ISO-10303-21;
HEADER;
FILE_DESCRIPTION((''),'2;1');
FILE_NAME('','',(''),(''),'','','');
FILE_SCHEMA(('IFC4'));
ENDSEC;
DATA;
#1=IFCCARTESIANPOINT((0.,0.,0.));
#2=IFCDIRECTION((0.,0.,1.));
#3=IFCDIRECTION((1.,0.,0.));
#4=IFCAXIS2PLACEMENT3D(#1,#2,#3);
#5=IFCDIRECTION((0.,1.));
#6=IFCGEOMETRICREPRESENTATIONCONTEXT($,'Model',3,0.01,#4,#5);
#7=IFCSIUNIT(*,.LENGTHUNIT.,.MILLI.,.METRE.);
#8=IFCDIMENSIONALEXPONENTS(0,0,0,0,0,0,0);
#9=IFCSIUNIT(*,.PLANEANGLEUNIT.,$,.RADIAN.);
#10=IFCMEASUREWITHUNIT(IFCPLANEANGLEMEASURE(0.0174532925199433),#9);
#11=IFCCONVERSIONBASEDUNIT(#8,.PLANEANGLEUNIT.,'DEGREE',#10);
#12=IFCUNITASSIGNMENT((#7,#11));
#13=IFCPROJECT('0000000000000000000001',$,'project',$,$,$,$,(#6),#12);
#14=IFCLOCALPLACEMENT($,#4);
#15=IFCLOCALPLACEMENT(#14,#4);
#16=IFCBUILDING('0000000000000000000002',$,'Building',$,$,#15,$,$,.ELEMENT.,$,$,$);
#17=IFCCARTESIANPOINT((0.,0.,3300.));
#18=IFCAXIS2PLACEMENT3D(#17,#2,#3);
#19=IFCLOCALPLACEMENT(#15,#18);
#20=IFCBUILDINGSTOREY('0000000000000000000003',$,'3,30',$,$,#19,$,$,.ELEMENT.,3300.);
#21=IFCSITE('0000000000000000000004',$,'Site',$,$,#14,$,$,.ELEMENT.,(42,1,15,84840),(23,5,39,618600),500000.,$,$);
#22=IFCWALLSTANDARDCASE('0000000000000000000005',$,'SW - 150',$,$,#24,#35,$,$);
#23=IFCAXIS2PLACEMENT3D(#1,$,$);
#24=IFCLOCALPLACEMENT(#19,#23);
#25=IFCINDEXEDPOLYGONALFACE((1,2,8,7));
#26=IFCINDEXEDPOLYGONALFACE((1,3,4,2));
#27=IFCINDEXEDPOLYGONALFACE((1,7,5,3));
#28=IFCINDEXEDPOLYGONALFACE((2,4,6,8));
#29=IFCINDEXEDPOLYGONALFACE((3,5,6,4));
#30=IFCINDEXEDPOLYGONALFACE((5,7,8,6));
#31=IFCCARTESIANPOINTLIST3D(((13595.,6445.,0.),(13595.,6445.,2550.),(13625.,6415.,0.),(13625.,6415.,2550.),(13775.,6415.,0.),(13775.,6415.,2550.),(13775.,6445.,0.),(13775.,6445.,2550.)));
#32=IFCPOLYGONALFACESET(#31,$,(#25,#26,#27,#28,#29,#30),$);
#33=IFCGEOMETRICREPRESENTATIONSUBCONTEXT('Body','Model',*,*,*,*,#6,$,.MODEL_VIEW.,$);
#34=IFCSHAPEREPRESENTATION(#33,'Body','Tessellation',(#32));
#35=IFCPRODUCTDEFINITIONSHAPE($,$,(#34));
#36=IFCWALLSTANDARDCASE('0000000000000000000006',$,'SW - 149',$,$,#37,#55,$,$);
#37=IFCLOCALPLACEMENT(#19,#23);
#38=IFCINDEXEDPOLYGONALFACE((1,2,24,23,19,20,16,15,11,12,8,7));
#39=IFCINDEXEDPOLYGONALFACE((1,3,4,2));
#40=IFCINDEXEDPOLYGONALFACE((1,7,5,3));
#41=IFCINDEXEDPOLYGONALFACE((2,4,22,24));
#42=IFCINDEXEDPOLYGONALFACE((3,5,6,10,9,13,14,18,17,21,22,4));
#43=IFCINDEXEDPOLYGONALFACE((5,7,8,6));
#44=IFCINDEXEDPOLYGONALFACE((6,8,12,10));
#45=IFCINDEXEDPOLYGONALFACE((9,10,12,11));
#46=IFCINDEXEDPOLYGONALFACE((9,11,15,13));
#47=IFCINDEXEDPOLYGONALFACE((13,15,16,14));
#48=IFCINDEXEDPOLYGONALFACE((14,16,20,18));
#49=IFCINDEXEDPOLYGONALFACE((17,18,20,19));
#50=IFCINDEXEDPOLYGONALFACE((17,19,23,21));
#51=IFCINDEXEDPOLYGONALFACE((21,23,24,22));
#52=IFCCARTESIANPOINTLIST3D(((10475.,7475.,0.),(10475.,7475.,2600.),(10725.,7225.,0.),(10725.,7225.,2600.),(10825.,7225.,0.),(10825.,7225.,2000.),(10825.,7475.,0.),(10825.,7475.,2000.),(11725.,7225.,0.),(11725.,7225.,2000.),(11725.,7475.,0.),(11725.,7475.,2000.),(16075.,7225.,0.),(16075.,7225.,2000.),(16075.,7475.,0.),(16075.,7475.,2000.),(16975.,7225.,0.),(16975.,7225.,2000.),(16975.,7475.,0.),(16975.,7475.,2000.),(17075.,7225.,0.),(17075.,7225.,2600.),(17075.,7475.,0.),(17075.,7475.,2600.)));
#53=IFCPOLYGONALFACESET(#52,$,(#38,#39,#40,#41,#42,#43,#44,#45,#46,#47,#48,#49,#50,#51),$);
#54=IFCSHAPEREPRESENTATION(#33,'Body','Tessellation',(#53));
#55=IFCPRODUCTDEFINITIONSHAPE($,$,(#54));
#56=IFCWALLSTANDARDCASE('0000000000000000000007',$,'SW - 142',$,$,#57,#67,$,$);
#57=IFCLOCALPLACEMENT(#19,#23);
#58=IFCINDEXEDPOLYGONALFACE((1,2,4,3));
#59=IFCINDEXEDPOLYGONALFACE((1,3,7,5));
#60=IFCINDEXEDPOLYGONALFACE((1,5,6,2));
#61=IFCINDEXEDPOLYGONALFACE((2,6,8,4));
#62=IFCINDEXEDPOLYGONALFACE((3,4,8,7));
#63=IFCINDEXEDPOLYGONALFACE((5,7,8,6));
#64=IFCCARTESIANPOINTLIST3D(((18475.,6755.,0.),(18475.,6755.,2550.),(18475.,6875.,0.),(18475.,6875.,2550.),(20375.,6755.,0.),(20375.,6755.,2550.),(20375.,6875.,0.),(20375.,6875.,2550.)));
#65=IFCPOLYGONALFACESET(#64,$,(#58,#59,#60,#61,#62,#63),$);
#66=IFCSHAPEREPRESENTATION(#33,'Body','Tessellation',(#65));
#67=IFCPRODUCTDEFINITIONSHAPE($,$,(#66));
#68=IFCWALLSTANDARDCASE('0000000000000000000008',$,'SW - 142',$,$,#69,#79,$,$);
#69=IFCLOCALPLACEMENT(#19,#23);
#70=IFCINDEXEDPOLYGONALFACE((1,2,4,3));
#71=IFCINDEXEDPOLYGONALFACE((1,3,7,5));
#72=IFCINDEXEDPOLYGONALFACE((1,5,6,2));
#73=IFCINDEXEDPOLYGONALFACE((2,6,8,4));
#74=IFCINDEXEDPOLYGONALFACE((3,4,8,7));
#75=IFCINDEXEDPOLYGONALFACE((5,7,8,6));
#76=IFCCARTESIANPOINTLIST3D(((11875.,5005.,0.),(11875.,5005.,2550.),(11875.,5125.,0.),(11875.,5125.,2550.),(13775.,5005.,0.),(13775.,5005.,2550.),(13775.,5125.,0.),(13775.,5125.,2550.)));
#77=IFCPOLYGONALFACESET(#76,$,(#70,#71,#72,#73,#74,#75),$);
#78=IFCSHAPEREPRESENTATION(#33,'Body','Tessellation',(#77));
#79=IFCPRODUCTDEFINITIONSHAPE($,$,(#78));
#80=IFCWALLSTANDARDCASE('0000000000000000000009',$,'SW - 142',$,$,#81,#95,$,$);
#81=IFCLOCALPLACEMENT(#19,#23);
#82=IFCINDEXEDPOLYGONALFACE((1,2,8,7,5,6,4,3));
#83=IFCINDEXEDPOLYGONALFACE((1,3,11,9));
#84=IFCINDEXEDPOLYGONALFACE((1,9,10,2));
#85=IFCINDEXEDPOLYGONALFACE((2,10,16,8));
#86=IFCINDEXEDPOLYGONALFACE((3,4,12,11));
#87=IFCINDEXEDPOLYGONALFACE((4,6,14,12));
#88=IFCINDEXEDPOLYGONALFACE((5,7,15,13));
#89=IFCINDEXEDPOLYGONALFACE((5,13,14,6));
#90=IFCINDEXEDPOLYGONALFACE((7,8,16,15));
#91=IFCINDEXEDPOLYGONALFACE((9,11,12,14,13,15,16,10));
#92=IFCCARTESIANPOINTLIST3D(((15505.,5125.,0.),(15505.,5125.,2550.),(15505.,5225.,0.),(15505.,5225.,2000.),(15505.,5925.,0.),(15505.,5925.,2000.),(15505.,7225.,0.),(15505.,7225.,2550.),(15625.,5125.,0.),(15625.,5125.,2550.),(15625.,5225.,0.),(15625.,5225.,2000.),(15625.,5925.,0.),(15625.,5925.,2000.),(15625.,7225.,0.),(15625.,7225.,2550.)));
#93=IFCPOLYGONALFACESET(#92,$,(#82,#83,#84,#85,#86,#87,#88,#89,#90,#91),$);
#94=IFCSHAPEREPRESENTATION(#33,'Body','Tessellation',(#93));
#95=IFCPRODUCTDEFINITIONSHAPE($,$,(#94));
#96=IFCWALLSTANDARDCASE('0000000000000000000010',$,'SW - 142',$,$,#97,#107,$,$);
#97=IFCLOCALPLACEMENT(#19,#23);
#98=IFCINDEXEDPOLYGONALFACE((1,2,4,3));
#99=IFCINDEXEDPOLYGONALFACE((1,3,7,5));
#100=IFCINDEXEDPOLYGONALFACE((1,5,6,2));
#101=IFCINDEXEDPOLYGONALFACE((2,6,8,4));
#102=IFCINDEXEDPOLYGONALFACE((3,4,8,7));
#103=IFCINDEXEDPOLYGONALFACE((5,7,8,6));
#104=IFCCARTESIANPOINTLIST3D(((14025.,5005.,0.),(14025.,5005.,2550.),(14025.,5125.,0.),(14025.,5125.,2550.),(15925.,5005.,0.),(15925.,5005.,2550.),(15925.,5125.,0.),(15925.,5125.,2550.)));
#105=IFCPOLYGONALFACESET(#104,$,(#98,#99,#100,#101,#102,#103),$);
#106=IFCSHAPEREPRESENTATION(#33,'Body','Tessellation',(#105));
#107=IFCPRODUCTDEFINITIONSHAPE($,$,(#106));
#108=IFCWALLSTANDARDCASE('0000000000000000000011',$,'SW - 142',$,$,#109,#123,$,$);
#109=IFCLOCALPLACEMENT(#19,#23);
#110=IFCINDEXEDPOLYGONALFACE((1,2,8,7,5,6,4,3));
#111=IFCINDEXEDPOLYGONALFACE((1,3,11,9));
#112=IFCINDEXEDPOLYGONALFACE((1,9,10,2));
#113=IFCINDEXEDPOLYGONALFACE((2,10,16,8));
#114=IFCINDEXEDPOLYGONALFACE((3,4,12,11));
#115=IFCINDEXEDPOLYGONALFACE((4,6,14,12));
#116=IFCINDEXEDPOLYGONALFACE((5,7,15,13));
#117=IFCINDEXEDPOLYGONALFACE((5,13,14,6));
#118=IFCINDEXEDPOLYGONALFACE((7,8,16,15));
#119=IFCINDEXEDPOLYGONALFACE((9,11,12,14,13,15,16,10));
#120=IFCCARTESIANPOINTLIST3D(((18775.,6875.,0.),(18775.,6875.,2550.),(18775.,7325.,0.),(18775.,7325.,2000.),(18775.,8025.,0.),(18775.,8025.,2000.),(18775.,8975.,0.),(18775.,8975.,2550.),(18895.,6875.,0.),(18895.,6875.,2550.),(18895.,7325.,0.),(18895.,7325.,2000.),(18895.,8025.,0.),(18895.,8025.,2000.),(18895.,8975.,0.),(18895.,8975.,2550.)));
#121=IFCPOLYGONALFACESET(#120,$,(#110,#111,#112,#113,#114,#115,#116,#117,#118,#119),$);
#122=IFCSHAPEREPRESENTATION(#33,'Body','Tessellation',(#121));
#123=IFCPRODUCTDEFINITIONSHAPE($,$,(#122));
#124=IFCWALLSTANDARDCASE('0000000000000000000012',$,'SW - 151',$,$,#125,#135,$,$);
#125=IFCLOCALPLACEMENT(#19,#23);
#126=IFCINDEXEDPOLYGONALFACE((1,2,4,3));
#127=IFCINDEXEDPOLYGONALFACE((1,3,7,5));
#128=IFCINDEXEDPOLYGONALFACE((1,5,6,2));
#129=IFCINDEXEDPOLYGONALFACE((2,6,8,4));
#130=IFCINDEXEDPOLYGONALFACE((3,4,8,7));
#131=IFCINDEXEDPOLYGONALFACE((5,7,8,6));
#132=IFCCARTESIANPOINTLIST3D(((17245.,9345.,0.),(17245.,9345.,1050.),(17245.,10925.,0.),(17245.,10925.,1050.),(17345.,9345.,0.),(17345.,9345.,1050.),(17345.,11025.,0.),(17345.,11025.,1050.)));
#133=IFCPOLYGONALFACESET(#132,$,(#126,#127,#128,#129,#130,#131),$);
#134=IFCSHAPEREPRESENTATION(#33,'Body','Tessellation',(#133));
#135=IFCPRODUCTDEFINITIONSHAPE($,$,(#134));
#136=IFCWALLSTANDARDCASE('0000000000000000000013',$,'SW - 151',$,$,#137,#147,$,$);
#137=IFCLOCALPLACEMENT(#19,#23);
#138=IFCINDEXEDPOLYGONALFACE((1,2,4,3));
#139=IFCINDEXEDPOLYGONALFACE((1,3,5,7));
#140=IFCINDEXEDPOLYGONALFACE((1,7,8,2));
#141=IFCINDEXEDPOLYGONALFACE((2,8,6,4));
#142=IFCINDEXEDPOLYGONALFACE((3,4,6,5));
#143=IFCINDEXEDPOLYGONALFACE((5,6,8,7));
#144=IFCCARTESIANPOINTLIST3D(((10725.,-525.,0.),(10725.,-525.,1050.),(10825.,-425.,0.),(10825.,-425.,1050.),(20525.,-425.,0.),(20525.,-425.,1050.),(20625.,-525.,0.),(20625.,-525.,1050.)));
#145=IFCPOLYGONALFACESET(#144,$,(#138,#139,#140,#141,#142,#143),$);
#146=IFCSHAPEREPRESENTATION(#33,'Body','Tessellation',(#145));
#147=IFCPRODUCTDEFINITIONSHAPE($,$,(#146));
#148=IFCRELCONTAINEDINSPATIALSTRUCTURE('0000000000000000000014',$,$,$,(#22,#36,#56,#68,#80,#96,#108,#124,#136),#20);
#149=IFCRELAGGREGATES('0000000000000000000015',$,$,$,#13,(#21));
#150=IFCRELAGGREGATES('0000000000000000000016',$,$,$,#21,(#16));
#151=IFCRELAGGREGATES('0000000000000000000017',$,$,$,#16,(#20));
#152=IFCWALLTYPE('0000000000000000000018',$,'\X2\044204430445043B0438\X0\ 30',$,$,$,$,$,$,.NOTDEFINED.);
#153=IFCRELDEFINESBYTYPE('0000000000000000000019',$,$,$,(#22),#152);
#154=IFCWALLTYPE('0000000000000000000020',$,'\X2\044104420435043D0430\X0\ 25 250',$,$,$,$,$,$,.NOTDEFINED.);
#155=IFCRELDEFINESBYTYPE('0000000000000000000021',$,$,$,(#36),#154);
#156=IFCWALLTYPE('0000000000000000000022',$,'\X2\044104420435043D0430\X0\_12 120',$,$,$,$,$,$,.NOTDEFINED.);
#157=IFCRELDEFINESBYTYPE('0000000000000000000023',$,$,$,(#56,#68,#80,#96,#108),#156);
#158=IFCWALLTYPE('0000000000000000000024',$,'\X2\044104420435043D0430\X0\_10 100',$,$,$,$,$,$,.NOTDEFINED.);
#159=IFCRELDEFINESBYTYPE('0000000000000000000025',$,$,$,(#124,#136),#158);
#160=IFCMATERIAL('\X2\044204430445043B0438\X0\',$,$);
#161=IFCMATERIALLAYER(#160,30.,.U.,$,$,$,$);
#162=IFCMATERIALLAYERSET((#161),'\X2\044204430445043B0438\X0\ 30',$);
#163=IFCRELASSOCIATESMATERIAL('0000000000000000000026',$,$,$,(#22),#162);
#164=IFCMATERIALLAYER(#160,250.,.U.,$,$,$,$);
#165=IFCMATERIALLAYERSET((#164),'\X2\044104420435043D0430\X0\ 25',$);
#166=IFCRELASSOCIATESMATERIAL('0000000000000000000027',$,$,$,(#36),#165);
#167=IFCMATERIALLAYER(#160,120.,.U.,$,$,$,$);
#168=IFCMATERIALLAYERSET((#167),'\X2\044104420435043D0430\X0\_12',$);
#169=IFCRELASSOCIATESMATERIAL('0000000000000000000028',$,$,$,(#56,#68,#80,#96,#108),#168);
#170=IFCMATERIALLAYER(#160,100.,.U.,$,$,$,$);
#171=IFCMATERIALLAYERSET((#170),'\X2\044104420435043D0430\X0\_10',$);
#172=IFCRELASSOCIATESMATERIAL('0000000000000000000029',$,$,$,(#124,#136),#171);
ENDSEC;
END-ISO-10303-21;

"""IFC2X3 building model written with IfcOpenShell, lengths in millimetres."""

from ifc_helpers import new_model, entity, si_unit, converted_unit, direction, frame, origin_with_axes, origin_2d_with_axis, place, context, subcontext, project, spatial, polyline, rectangle, outline, extrude, material, layer, layer_set, layer_usage, type_object, element, save


model = new_model("IFC2X3")

# Units and contexts
model_context = context("Model", 3, precision=0.01, world=origin_with_axes(), true_north=direction((0.0, 1.0)))
body_context = subcontext(model_context, "Body", "Model", "MODEL_VIEW")
ifc_project = project(units=[si_unit("LENGTHUNIT", "METRE", prefix="MILLI"), converted_unit("PLANEANGLEUNIT", "DEGREE", entity("IfcPlaneAngleMeasure", 0.0174532925199433), si_unit("PLANEANGLEUNIT", "RADIAN"), dimensions=[0, 0, 0, 0, 0, 0, 0])], contexts=[model_context])

# Site, building, storey
site_placement = place(None, origin_with_axes())
site = spatial("IfcSite", under=ifc_project, at=site_placement, Name="Site", CompositionType="ELEMENT", RefLatitude=(42, 1, 15, 84840), RefLongitude=(23, 5, 39, 618600), RefElevation=500000.0)
building_placement = place(site_placement, origin_with_axes())
building = spatial("IfcBuilding", under=site, at=building_placement, Name="Building", CompositionType="ELEMENT")
storey_placement = place(building_placement, frame((0.0, 0.0, 3300.0), z_axis=(0.0, 0.0, 1.0), x_axis=(1.0, 0.0, 0.0)))
storey = spatial("IfcBuildingStorey", under=building, at=storey_placement, Name="3,30", CompositionType="ELEMENT", Elevation=3300.0)

# Shared definitions
ifc_material_1 = material(Name="тухли")

# Wall
ifc_layer_1 = layer(ifc_material_1, 30.0, ventilated="UNKNOWN")
ifc_layer_set_1 = layer_set([ifc_layer_1], Name="тухли 30")
wall_type_1 = type_object("IfcWallType", Name="тухли 30", PredefinedType="NOTDEFINED")
ifc_layer_usage_1 = layer_usage(ifc_layer_set_1, "AXIS2", "NEGATIVE", 0.0)
wall_1_placement = place(storey_placement, frame((13595.0, 6445.0, 0.0), z_axis=(0.0, 0.0, 1.0), x_axis=(1.0, 0.0, 0.0)))
element("IfcWallStandardCase", 1, at=wall_1_placement, inside=storey, type_object=wall_type_1, material=ifc_layer_usage_1, Name="SW - 150", context=body_context, shape_type="SweptSolid", body=[
    extrude(outline(polyline([(30.0, -30.0), (180.0, -30.0), (180.0, 0.0), (0.0, 0.0), (30.0, -30.0)])), origin_with_axes(), (0.0, 0.0, 1.0), 2550.0),
])

# Shared definitions
ifc_layer_2 = layer(ifc_material_1, 250.0, ventilated="UNKNOWN")
ifc_layer_set_2 = layer_set([ifc_layer_2], Name="стена 25")
wall_type_2 = type_object("IfcWallType", Name="стена 25 250", PredefinedType="NOTDEFINED")

# Wall, openings
ifc_layer_usage_2 = layer_usage(ifc_layer_set_2, "AXIS2", "NEGATIVE", 0.0)
wall_2_placement = place(storey_placement, frame((17075.0, 7225.0, 0.0), z_axis=(0.0, 0.0, 1.0), x_axis=(-1.0, 0.0, 0.0)))
wall_2 = element("IfcWallStandardCase", 2, at=wall_2_placement, inside=storey, type_object=wall_type_2, material=ifc_layer_usage_2, Name="SW - 149", context=body_context, shape_type="SweptSolid", body=[
    extrude(outline(polyline([(0.0, -250.0), (6600.0, -250.0), (6350.0, 0.0), (0.0, 0.0), (0.0, -250.0)])), origin_with_axes(), (0.0, 0.0, 1.0), 2600.0),
])
opening_1_placement = place(wall_2_placement, frame((5800.0, 0.0, 0.0), z_axis=(0.0, 0.0, 1.0), x_axis=(1.0, 0.0, 0.0)))
element("IfcOpeningElement", 3, at=opening_1_placement, cuts=wall_2, context=body_context, shape_type="SweptSolid", body=[
    extrude(rectangle(XDim=900.0, YDim=2000.0, at=origin_2d_with_axis()), frame((0.0, -250.0, 1000.0), z_axis=(0.0, 1.0, 0.0), x_axis=(1.0, 0.0, 0.0)), (0.0, 0.0, 1.0), 750.0),
])
opening_2_placement = place(wall_2_placement, frame((550.0, 0.0, 0.0), z_axis=(0.0, 0.0, 1.0), x_axis=(1.0, 0.0, 0.0)))
element("IfcOpeningElement", 4, at=opening_2_placement, cuts=wall_2, context=body_context, shape_type="SweptSolid", body=[
    extrude(rectangle(XDim=900.0, YDim=2000.0, at=origin_2d_with_axis()), frame((0.0, -250.0, 1000.0), z_axis=(0.0, -1.0, 0.0), x_axis=(-1.0, 0.0, 0.0)), (0.0, 0.0, -1.0), 750.0),
])

# Walls
ifc_layer_3 = layer(ifc_material_1, 120.0, ventilated="UNKNOWN")
ifc_layer_set_3 = layer_set([ifc_layer_3], Name="стена_12")
ifc_layer_usage_3 = layer_usage(ifc_layer_set_3, "AXIS2", "POSITIVE", -60.0)
wall_type_3 = type_object("IfcWallType", Name="стена_12 120", PredefinedType="NOTDEFINED")
wall_3_placement = place(storey_placement, frame((20375.0, 6815.0, 0.0), z_axis=(0.0, 0.0, 1.0), x_axis=(-1.0, 0.0, 0.0)))
element("IfcWallStandardCase", 5, at=wall_3_placement, inside=storey, type_object=wall_type_3, material=ifc_layer_usage_3, Name="SW - 142", context=body_context, shape_type="SweptSolid", body=[
    extrude(outline(polyline([(0.0, -60.0), (1900.0, -60.0), (1900.0, 60.0), (0.0, 60.0), (0.0, -60.0)])), origin_with_axes(), (0.0, 0.0, 1.0), 2550.0),
])
ifc_layer_usage_4 = layer_usage(ifc_layer_set_3, "AXIS2", "POSITIVE", -60.0)
wall_4_placement = place(storey_placement, frame((13775.0, 5065.0, 0.0), z_axis=(0.0, 0.0, 1.0), x_axis=(-1.0, 0.0, 0.0)))
element("IfcWallStandardCase", 6, at=wall_4_placement, inside=storey, type_object=wall_type_3, material=ifc_layer_usage_4, Name="SW - 142", context=body_context, shape_type="SweptSolid", body=[
    extrude(outline(polyline([(0.0, -60.0), (1900.0, -60.0), (1900.0, 60.0), (0.0, 60.0), (0.0, -60.0)])), origin_with_axes(), (0.0, 0.0, 1.0), 2550.0),
])

# Wall, opening
ifc_layer_usage_5 = layer_usage(ifc_layer_set_3, "AXIS2", "NEGATIVE", 60.0)
wall_5_placement = place(storey_placement, frame((15565.0, 7225.0, 0.0), z_axis=(0.0, 0.0, 1.0), x_axis=(0.0, -1.0, 0.0)))
wall_5 = element("IfcWallStandardCase", 7, at=wall_5_placement, inside=storey, type_object=wall_type_3, material=ifc_layer_usage_5, Name="SW - 142", context=body_context, shape_type="SweptSolid", body=[
    extrude(outline(polyline([(0.0, -60.0), (2100.0, -60.0), (2100.0, 60.0), (0.0, 60.0), (0.0, -60.0)])), origin_with_axes(), (0.0, 0.0, 1.0), 2550.0),
])
opening_3_placement = place(wall_5_placement, frame((1650.0, 0.0, 0.0), z_axis=(0.0, 0.0, 1.0), x_axis=(1.0, 0.0, 0.0)))
element("IfcOpeningElement", 8, at=opening_3_placement, cuts=wall_5, context=body_context, shape_type="SweptSolid", body=[
    extrude(rectangle(XDim=700.0, YDim=2000.0, at=origin_2d_with_axis()), frame((0.0, 120.0, 1000.0), z_axis=(0.0, 1.0, 0.0), x_axis=(1.0, 0.0, 0.0)), (0.0, 0.0, -1.0), 360.0),
])

# Wall
ifc_layer_usage_6 = layer_usage(ifc_layer_set_3, "AXIS2", "NEGATIVE", 60.0)
wall_6_placement = place(storey_placement, frame((14025.0, 5065.0, 0.0), z_axis=(0.0, 0.0, 1.0), x_axis=(1.0, 0.0, 0.0)))
element("IfcWallStandardCase", 9, at=wall_6_placement, inside=storey, type_object=wall_type_3, material=ifc_layer_usage_6, Name="SW - 142", context=body_context, shape_type="SweptSolid", body=[
    extrude(outline(polyline([(0.0, -60.0), (1900.0, -60.0), (1900.0, 60.0), (0.0, 60.0), (0.0, -60.0)])), origin_with_axes(), (0.0, 0.0, 1.0), 2550.0),
])

# Wall, opening
ifc_layer_usage_7 = layer_usage(ifc_layer_set_3, "AXIS2", "POSITIVE", -60.0)
wall_7_placement = place(storey_placement, frame((18835.0, 8975.0, 0.0), z_axis=(0.0, 0.0, 1.0), x_axis=(0.0, -1.0, 0.0)))
wall_7 = element("IfcWallStandardCase", 10, at=wall_7_placement, inside=storey, type_object=wall_type_3, material=ifc_layer_usage_7, Name="SW - 142", context=body_context, shape_type="SweptSolid", body=[
    extrude(outline(polyline([(0.0, -60.0), (2100.0, -60.0), (2100.0, 60.0), (0.0, 60.0), (0.0, -60.0)])), origin_with_axes(), (0.0, 0.0, 1.0), 2550.0),
])
opening_4_placement = place(wall_7_placement, frame((1300.0, 0.0, 0.0), z_axis=(0.0, 0.0, 1.0), x_axis=(1.0, 0.0, 0.0)))
element("IfcOpeningElement", 11, at=opening_4_placement, cuts=wall_7, context=body_context, shape_type="SweptSolid", body=[
    extrude(rectangle(XDim=700.0, YDim=2000.0, at=origin_2d_with_axis()), frame((0.0, -120.0, 1000.0), z_axis=(0.0, -1.0, 0.0), x_axis=(-1.0, 0.0, 0.0)), (0.0, 0.0, -1.0), 360.0),
])

# Walls
ifc_layer_4 = layer(ifc_material_1, 100.0, ventilated="UNKNOWN")
ifc_layer_set_4 = layer_set([ifc_layer_4], Name="стена_10")
ifc_layer_usage_8 = layer_usage(ifc_layer_set_4, "AXIS2", "NEGATIVE", 0.0)
wall_type_4 = type_object("IfcWallType", Name="стена_10 100", PredefinedType="NOTDEFINED")
wall_8_placement = place(storey_placement, frame((17345.0, 11025.0, 0.0), z_axis=(0.0, 0.0, 1.0), x_axis=(0.0, -1.0, 0.0)))
element("IfcWallStandardCase", 12, at=wall_8_placement, inside=storey, type_object=wall_type_4, material=ifc_layer_usage_8, Name="SW - 151", context=body_context, shape_type="SweptSolid", body=[
    extrude(outline(polyline([(100.0, -100.0), (1680.0, -100.0), (1680.0, 0.0), (0.0, 0.0), (100.0, -100.0)])), origin_with_axes(), (0.0, 0.0, 1.0), 1050.0),
])
ifc_layer_usage_9 = layer_usage(ifc_layer_set_4, "AXIS2", "NEGATIVE", 0.0)
wall_9_placement = place(storey_placement, frame((20625.0, -525.0, 0.0), z_axis=(0.0, 0.0, 1.0), x_axis=(-1.0, 0.0, 0.0)))
element("IfcWallStandardCase", 13, at=wall_9_placement, inside=storey, type_object=wall_type_4, material=ifc_layer_usage_9, Name="SW - 151", context=body_context, shape_type="SweptSolid", body=[
    extrude(outline(polyline([(100.0, -100.0), (9800.0, -100.0), (9900.0, 0.0), (0.0, 0.0), (100.0, -100.0)])), origin_with_axes(), (0.0, 0.0, 1.0), 1050.0),
])

save(model, "model.ifc")
